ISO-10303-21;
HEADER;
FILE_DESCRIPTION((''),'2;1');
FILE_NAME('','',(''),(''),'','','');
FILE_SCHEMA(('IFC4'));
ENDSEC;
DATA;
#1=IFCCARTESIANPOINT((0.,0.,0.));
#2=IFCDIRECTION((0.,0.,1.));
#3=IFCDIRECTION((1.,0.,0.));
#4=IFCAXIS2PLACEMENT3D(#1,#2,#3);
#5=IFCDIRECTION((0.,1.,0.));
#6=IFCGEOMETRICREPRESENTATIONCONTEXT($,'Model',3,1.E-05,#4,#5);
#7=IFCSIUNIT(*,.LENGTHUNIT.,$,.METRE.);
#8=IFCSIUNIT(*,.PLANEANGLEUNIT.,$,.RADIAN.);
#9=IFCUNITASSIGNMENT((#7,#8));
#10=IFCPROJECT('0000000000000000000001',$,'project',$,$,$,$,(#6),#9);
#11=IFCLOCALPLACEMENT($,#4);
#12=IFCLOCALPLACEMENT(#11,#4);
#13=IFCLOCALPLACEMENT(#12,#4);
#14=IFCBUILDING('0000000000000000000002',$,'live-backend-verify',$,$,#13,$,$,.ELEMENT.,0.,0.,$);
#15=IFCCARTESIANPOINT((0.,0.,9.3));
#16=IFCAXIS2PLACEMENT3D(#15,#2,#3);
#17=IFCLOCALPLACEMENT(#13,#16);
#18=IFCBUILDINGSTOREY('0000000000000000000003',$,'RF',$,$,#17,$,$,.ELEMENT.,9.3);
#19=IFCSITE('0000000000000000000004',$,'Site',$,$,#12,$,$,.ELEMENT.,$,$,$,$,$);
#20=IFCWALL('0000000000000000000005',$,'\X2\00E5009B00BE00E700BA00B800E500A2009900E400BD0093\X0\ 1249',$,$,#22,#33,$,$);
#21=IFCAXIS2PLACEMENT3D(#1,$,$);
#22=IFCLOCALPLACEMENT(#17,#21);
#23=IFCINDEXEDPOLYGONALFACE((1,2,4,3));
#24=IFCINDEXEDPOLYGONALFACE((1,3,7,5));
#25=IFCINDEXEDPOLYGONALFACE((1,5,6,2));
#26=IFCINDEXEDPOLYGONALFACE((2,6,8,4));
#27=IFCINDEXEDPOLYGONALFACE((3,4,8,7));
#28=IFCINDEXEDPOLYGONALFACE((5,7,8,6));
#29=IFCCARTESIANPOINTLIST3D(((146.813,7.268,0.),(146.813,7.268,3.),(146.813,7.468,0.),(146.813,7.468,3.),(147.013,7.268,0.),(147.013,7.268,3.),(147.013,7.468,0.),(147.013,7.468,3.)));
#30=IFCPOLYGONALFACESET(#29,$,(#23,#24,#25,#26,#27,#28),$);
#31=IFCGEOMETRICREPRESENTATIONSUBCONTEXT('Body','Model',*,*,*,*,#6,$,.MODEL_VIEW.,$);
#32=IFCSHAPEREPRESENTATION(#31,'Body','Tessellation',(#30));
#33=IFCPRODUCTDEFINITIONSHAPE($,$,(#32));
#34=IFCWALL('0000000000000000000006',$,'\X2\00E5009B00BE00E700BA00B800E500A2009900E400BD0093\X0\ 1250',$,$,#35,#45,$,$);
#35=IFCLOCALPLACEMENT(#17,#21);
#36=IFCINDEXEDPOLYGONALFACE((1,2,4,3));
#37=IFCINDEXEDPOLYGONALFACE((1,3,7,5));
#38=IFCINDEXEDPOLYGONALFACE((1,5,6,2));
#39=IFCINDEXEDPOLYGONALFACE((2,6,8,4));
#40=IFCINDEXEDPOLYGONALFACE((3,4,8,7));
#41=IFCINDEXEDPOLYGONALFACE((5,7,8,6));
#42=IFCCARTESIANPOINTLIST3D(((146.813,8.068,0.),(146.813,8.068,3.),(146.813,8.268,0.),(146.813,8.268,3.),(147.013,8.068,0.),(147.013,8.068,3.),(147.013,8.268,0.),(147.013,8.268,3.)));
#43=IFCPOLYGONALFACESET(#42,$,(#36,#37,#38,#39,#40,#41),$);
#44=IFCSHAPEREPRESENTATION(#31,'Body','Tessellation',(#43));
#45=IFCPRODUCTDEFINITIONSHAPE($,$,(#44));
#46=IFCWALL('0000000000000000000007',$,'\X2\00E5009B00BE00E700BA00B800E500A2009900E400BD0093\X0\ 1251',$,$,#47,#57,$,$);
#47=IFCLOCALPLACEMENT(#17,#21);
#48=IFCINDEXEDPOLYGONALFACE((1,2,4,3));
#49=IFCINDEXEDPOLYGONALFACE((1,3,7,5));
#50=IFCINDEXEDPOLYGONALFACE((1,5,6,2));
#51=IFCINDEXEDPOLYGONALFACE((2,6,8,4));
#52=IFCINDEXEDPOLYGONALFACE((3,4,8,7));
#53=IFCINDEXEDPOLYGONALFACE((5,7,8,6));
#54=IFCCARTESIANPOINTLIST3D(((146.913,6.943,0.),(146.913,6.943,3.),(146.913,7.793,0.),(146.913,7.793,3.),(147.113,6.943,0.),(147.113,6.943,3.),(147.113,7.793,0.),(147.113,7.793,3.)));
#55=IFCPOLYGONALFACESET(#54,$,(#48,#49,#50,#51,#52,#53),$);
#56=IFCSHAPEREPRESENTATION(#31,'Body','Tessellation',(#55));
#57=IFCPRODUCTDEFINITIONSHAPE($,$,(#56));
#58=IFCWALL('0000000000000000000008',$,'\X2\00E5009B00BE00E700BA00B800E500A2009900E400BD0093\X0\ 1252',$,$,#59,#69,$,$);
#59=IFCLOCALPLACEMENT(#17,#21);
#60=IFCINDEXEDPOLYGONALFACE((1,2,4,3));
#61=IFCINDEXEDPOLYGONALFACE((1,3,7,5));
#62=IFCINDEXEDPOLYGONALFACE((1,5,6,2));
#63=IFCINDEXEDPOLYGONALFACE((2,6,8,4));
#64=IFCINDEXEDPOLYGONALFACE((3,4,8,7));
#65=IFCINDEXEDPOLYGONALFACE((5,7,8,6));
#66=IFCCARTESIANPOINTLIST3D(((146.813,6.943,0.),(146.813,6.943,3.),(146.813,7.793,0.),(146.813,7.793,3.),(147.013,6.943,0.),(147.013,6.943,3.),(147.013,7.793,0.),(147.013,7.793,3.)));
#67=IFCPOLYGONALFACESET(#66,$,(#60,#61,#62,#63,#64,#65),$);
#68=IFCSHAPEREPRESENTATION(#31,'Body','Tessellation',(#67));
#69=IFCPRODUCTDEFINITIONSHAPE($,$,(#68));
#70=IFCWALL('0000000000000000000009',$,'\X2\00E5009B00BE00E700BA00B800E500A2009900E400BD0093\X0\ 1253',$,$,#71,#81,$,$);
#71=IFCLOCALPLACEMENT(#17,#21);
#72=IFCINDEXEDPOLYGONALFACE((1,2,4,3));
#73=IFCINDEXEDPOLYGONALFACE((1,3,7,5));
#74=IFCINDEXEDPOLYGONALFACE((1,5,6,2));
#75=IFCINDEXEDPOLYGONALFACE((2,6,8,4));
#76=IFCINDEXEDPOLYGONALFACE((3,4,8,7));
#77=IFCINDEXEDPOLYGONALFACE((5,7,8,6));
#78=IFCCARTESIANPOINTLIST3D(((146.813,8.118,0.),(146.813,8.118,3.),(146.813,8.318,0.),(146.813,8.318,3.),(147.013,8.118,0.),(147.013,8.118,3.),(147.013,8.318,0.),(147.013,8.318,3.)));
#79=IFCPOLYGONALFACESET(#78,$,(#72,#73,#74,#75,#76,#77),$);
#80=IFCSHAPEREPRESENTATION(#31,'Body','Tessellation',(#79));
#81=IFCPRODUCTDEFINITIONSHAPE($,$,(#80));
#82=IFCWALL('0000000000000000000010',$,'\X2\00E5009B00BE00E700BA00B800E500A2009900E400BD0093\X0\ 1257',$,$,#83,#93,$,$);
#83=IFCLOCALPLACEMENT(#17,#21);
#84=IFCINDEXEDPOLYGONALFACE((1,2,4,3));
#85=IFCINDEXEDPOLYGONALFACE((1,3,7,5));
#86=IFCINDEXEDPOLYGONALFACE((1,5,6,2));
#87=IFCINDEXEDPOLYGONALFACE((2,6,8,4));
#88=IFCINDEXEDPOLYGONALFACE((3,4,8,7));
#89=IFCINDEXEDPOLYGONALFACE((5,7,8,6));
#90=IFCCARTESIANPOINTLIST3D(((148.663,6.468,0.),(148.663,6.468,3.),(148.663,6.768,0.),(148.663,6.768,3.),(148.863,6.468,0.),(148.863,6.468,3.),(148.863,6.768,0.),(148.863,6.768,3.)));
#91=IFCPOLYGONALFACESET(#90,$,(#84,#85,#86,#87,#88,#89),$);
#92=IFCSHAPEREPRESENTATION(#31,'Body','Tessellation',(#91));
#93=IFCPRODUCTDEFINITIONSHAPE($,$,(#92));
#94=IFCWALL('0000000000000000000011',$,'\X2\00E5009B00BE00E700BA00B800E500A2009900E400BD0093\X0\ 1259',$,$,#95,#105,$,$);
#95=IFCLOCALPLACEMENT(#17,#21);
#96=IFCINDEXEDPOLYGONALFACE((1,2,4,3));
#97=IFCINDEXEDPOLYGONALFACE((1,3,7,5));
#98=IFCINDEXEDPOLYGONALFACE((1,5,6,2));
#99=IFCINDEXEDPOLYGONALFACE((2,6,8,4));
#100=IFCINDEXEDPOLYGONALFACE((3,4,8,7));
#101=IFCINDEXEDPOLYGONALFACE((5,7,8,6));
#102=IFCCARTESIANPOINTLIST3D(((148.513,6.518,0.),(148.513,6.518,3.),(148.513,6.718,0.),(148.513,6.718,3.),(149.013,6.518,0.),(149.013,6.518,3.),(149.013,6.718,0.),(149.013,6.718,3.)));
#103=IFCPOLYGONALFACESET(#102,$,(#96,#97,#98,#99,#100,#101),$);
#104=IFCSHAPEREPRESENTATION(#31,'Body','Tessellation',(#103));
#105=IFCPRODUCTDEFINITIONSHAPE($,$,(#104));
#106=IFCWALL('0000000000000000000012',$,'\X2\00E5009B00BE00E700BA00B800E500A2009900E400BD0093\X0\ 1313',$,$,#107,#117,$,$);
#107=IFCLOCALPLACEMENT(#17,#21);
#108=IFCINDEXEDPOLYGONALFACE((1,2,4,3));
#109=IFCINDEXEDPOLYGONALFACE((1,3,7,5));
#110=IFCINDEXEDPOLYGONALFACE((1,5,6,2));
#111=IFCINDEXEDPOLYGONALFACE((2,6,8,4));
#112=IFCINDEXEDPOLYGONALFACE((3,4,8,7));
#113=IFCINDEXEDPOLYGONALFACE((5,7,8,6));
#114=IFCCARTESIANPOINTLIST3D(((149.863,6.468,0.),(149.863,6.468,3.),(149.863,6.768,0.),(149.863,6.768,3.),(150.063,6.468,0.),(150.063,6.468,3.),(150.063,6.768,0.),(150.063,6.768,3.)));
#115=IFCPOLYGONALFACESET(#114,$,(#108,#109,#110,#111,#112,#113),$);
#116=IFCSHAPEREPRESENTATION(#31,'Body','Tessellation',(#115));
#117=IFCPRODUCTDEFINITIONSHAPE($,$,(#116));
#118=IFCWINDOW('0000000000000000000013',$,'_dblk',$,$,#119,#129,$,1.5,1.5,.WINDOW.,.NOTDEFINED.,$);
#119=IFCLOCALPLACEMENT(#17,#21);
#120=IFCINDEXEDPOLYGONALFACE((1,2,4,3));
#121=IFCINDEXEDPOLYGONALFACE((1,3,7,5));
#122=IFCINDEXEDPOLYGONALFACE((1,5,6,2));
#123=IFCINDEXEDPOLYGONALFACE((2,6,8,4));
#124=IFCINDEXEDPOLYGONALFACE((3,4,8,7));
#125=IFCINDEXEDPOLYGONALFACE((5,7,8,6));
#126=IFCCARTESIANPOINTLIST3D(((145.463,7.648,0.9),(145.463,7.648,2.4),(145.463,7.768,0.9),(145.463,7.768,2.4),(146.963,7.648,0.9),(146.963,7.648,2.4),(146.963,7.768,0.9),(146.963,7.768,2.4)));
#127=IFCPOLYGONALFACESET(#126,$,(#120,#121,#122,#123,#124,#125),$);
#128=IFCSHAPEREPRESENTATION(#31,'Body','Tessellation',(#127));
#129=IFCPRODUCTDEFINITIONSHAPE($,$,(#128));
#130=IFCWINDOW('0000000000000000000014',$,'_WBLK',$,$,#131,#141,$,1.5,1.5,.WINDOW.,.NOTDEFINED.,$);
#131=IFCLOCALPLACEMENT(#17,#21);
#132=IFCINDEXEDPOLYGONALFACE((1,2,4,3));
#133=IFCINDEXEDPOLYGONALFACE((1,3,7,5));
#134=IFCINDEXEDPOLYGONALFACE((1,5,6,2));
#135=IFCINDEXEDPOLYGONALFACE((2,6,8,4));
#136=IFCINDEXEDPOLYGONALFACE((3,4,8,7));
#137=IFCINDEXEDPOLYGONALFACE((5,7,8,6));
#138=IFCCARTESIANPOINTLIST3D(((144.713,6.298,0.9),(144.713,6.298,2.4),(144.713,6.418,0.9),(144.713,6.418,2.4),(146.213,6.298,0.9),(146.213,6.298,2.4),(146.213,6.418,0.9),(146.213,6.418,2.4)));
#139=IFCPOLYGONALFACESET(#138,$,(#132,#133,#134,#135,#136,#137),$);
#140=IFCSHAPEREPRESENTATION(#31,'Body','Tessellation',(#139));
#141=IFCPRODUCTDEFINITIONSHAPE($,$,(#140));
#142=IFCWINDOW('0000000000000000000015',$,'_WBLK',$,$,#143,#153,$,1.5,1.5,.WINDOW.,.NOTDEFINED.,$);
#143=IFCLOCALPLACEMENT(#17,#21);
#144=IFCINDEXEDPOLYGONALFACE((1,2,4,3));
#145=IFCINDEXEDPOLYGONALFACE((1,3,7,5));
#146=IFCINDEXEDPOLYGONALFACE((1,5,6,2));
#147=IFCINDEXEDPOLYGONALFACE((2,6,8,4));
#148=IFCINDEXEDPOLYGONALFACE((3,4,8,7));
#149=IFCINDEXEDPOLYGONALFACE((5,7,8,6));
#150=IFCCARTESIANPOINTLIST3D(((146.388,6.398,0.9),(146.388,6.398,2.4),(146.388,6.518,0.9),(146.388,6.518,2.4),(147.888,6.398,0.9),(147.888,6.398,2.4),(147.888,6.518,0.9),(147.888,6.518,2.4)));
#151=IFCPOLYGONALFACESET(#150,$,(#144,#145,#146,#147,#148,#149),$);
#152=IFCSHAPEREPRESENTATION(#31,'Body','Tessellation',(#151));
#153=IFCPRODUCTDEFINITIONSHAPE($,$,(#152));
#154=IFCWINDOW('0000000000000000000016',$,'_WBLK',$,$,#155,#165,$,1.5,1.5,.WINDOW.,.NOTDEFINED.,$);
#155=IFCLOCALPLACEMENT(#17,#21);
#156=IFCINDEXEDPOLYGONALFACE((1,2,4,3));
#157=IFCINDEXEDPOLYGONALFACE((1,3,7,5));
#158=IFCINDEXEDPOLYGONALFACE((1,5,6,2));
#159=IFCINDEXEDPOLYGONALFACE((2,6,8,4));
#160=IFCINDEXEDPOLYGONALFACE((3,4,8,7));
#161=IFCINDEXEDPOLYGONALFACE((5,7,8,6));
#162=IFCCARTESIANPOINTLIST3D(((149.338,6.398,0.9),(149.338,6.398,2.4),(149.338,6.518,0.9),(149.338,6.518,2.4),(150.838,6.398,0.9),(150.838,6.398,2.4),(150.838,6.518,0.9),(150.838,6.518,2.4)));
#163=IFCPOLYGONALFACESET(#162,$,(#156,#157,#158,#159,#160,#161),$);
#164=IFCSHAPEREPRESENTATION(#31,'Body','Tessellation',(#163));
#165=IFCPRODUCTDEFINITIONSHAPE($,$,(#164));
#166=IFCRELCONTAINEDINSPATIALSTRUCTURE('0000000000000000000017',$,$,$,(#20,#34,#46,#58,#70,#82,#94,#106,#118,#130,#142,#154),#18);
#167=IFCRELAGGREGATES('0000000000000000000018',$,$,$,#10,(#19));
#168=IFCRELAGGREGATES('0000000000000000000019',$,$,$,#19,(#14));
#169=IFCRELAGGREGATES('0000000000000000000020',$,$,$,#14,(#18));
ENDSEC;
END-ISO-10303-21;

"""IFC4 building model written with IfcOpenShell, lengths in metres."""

from ifc_helpers import new_model, si_unit, direction, frame, frame_2d, origin_with_axes, place, context, subcontext, project, spatial, rectangle, extrude, element, save


model = new_model("IFC4")

# Units and contexts
model_context = context("Model", 3, precision=1e-05, world=origin_with_axes(), true_north=direction((0.0, 1.0, 0.0)))
body_context = subcontext(model_context, "Body", "Model", "MODEL_VIEW")
ifc_project = project(units=[si_unit("LENGTHUNIT", "METRE"), si_unit("PLANEANGLEUNIT", "RADIAN")], contexts=[model_context])

# Site, building, storey
placement = place(None, origin_with_axes())
site_placement = place(placement, origin_with_axes())
site = spatial("IfcSite", under=ifc_project, at=site_placement, Name="Site", CompositionType="ELEMENT")
building_placement = place(site_placement, origin_with_axes())
building = spatial("IfcBuilding", under=site, at=building_placement, Name="live-backend-verify", CompositionType="ELEMENT", ElevationOfRefHeight=0.0, ElevationOfTerrain=0.0)
storey_placement = place(building_placement, frame((0.0, 0.0, 9.3), z_axis=(0.0, 0.0, 1.0), x_axis=(1.0, 0.0, 0.0)))
storey = spatial("IfcBuildingStorey", under=building, at=storey_placement, Name="RF", CompositionType="ELEMENT", Elevation=9.3)

# Walls
for number, where, z_axis, x_axis, name in (
    (1, (146.913, 7.368, 0.0), (0.0, 0.0, 1.0), (1.0, 0.0, 0.0), "å\u009b¾çº¸å¢\u0099ä½\u0093 1249"),
    (2, (146.913, 8.168, 0.0), (0.0, 0.0, 1.0), (1.0, 0.0, 0.0), "å\u009b¾çº¸å¢\u0099ä½\u0093 1250"),
):
    element("IfcWall", number, at=place(storey_placement, frame(where, z_axis=z_axis, x_axis=x_axis)), inside=storey, Name=name, context=body_context, shape_type="SweptSolid", body=[
        extrude(rectangle(XDim=0.2, YDim=0.2, at=frame_2d((0.0, 0.0), x_axis=(1.0, 0.0, 0.0))), frame((0.0, 0.0, 0.0), z_axis=(0.0, 0.0, 1.0)), (0.0, 0.0, 1.0), 3.0),
    ])
for number, where, z_axis, x_axis, name in (
    (3, (147.013, 7.368, 0.0), (0.0, 0.0, 1.0), (0.0, -1.0, 0.0), "å\u009b¾çº¸å¢\u0099ä½\u0093 1251"),
    (4, (146.913, 7.368, 0.0), (0.0, 0.0, 1.0), (0.0, -1.0, 0.0), "å\u009b¾çº¸å¢\u0099ä½\u0093 1252"),
):
    element("IfcWall", number, at=place(storey_placement, frame(where, z_axis=z_axis, x_axis=x_axis)), inside=storey, Name=name, context=body_context, shape_type="SweptSolid", body=[
        extrude(rectangle(XDim=0.85, YDim=0.2, at=frame_2d((0.0, 0.0), x_axis=(1.0, 0.0, 0.0))), frame((0.0, 0.0, 0.0), z_axis=(0.0, 0.0, 1.0)), (0.0, 0.0, 1.0), 3.0),
    ])
wall_1_placement = place(storey_placement, frame((146.913, 8.218, 0.0), z_axis=(0.0, 0.0, 1.0), x_axis=(0.0, -1.0, 0.0)))
element("IfcWall", 5, at=wall_1_placement, inside=storey, Name="å\u009b¾çº¸å¢\u0099ä½\u0093 1253", context=body_context, shape_type="SweptSolid", body=[
    extrude(rectangle(XDim=0.2, YDim=0.2, at=frame_2d((0.0, 0.0), x_axis=(1.0, 0.0, 0.0))), frame((0.0, 0.0, 0.0), z_axis=(0.0, 0.0, 1.0)), (0.0, 0.0, 1.0), 3.0),
])
wall_2_placement = place(storey_placement, frame((148.763, 6.618, 0.0), z_axis=(0.0, 0.0, 1.0), x_axis=(0.0, -1.0, 0.0)))
element("IfcWall", 6, at=wall_2_placement, inside=storey, Name="å\u009b¾çº¸å¢\u0099ä½\u0093 1257", context=body_context, shape_type="SweptSolid", body=[
    extrude(rectangle(XDim=0.3, YDim=0.2, at=frame_2d((0.0, 0.0), x_axis=(1.0, 0.0, 0.0))), frame((0.0, 0.0, 0.0), z_axis=(0.0, 0.0, 1.0)), (0.0, 0.0, 1.0), 3.0),
])
wall_3_placement = place(storey_placement, frame((148.763, 6.618, 0.0), z_axis=(0.0, 0.0, 1.0), x_axis=(1.0, 0.0, 0.0)))
element("IfcWall", 7, at=wall_3_placement, inside=storey, Name="å\u009b¾çº¸å¢\u0099ä½\u0093 1259", context=body_context, shape_type="SweptSolid", body=[
    extrude(rectangle(XDim=0.5, YDim=0.2, at=frame_2d((0.0, 0.0), x_axis=(1.0, 0.0, 0.0))), frame((0.0, 0.0, 0.0), z_axis=(0.0, 0.0, 1.0)), (0.0, 0.0, 1.0), 3.0),
])
wall_4_placement = place(storey_placement, frame((149.963, 6.618, 0.0), z_axis=(0.0, 0.0, 1.0), x_axis=(0.0, -1.0, 0.0)))
element("IfcWall", 8, at=wall_4_placement, inside=storey, Name="å\u009b¾çº¸å¢\u0099ä½\u0093 1313", context=body_context, shape_type="SweptSolid", body=[
    extrude(rectangle(XDim=0.3, YDim=0.2, at=frame_2d((0.0, 0.0), x_axis=(1.0, 0.0, 0.0))), frame((0.0, 0.0, 0.0), z_axis=(0.0, 0.0, 1.0)), (0.0, 0.0, 1.0), 3.0),
])

# Windows
for number, where, z_axis, x_axis, name in (
    (9, (146.213, 7.708, 0.9), (0.0, 0.0, 1.0), (1.0, 0.0, 0.0), "_dblk"),
    (10, (145.463, 6.358, 0.9), (0.0, 0.0, 1.0), (1.0, 0.0, 0.0), "_WBLK"),
    (11, (147.138, 6.458, 0.9), (0.0, 0.0, 1.0), (1.0, 0.0, 0.0), "_WBLK"),
    (12, (150.088, 6.458, 0.9), (0.0, 0.0, 1.0), (1.0, 0.0, 0.0), "_WBLK"),
):
    element("IfcWindow", number, at=place(storey_placement, frame(where, z_axis=z_axis, x_axis=x_axis)), inside=storey, Name=name, OverallHeight=1.5, OverallWidth=1.5, PartitioningType="NOTDEFINED", PredefinedType="WINDOW", context=body_context, shape_type="SweptSolid", body=[
        extrude(rectangle(XDim=1.5, YDim=0.12, at=frame_2d((0.0, 0.0), x_axis=(1.0, 0.0, 0.0))), frame((0.0, 0.0, 0.0), z_axis=(0.0, 0.0, 1.0)), (0.0, 0.0, 1.0), 1.5),
    ])

save(model, "model.ifc")
